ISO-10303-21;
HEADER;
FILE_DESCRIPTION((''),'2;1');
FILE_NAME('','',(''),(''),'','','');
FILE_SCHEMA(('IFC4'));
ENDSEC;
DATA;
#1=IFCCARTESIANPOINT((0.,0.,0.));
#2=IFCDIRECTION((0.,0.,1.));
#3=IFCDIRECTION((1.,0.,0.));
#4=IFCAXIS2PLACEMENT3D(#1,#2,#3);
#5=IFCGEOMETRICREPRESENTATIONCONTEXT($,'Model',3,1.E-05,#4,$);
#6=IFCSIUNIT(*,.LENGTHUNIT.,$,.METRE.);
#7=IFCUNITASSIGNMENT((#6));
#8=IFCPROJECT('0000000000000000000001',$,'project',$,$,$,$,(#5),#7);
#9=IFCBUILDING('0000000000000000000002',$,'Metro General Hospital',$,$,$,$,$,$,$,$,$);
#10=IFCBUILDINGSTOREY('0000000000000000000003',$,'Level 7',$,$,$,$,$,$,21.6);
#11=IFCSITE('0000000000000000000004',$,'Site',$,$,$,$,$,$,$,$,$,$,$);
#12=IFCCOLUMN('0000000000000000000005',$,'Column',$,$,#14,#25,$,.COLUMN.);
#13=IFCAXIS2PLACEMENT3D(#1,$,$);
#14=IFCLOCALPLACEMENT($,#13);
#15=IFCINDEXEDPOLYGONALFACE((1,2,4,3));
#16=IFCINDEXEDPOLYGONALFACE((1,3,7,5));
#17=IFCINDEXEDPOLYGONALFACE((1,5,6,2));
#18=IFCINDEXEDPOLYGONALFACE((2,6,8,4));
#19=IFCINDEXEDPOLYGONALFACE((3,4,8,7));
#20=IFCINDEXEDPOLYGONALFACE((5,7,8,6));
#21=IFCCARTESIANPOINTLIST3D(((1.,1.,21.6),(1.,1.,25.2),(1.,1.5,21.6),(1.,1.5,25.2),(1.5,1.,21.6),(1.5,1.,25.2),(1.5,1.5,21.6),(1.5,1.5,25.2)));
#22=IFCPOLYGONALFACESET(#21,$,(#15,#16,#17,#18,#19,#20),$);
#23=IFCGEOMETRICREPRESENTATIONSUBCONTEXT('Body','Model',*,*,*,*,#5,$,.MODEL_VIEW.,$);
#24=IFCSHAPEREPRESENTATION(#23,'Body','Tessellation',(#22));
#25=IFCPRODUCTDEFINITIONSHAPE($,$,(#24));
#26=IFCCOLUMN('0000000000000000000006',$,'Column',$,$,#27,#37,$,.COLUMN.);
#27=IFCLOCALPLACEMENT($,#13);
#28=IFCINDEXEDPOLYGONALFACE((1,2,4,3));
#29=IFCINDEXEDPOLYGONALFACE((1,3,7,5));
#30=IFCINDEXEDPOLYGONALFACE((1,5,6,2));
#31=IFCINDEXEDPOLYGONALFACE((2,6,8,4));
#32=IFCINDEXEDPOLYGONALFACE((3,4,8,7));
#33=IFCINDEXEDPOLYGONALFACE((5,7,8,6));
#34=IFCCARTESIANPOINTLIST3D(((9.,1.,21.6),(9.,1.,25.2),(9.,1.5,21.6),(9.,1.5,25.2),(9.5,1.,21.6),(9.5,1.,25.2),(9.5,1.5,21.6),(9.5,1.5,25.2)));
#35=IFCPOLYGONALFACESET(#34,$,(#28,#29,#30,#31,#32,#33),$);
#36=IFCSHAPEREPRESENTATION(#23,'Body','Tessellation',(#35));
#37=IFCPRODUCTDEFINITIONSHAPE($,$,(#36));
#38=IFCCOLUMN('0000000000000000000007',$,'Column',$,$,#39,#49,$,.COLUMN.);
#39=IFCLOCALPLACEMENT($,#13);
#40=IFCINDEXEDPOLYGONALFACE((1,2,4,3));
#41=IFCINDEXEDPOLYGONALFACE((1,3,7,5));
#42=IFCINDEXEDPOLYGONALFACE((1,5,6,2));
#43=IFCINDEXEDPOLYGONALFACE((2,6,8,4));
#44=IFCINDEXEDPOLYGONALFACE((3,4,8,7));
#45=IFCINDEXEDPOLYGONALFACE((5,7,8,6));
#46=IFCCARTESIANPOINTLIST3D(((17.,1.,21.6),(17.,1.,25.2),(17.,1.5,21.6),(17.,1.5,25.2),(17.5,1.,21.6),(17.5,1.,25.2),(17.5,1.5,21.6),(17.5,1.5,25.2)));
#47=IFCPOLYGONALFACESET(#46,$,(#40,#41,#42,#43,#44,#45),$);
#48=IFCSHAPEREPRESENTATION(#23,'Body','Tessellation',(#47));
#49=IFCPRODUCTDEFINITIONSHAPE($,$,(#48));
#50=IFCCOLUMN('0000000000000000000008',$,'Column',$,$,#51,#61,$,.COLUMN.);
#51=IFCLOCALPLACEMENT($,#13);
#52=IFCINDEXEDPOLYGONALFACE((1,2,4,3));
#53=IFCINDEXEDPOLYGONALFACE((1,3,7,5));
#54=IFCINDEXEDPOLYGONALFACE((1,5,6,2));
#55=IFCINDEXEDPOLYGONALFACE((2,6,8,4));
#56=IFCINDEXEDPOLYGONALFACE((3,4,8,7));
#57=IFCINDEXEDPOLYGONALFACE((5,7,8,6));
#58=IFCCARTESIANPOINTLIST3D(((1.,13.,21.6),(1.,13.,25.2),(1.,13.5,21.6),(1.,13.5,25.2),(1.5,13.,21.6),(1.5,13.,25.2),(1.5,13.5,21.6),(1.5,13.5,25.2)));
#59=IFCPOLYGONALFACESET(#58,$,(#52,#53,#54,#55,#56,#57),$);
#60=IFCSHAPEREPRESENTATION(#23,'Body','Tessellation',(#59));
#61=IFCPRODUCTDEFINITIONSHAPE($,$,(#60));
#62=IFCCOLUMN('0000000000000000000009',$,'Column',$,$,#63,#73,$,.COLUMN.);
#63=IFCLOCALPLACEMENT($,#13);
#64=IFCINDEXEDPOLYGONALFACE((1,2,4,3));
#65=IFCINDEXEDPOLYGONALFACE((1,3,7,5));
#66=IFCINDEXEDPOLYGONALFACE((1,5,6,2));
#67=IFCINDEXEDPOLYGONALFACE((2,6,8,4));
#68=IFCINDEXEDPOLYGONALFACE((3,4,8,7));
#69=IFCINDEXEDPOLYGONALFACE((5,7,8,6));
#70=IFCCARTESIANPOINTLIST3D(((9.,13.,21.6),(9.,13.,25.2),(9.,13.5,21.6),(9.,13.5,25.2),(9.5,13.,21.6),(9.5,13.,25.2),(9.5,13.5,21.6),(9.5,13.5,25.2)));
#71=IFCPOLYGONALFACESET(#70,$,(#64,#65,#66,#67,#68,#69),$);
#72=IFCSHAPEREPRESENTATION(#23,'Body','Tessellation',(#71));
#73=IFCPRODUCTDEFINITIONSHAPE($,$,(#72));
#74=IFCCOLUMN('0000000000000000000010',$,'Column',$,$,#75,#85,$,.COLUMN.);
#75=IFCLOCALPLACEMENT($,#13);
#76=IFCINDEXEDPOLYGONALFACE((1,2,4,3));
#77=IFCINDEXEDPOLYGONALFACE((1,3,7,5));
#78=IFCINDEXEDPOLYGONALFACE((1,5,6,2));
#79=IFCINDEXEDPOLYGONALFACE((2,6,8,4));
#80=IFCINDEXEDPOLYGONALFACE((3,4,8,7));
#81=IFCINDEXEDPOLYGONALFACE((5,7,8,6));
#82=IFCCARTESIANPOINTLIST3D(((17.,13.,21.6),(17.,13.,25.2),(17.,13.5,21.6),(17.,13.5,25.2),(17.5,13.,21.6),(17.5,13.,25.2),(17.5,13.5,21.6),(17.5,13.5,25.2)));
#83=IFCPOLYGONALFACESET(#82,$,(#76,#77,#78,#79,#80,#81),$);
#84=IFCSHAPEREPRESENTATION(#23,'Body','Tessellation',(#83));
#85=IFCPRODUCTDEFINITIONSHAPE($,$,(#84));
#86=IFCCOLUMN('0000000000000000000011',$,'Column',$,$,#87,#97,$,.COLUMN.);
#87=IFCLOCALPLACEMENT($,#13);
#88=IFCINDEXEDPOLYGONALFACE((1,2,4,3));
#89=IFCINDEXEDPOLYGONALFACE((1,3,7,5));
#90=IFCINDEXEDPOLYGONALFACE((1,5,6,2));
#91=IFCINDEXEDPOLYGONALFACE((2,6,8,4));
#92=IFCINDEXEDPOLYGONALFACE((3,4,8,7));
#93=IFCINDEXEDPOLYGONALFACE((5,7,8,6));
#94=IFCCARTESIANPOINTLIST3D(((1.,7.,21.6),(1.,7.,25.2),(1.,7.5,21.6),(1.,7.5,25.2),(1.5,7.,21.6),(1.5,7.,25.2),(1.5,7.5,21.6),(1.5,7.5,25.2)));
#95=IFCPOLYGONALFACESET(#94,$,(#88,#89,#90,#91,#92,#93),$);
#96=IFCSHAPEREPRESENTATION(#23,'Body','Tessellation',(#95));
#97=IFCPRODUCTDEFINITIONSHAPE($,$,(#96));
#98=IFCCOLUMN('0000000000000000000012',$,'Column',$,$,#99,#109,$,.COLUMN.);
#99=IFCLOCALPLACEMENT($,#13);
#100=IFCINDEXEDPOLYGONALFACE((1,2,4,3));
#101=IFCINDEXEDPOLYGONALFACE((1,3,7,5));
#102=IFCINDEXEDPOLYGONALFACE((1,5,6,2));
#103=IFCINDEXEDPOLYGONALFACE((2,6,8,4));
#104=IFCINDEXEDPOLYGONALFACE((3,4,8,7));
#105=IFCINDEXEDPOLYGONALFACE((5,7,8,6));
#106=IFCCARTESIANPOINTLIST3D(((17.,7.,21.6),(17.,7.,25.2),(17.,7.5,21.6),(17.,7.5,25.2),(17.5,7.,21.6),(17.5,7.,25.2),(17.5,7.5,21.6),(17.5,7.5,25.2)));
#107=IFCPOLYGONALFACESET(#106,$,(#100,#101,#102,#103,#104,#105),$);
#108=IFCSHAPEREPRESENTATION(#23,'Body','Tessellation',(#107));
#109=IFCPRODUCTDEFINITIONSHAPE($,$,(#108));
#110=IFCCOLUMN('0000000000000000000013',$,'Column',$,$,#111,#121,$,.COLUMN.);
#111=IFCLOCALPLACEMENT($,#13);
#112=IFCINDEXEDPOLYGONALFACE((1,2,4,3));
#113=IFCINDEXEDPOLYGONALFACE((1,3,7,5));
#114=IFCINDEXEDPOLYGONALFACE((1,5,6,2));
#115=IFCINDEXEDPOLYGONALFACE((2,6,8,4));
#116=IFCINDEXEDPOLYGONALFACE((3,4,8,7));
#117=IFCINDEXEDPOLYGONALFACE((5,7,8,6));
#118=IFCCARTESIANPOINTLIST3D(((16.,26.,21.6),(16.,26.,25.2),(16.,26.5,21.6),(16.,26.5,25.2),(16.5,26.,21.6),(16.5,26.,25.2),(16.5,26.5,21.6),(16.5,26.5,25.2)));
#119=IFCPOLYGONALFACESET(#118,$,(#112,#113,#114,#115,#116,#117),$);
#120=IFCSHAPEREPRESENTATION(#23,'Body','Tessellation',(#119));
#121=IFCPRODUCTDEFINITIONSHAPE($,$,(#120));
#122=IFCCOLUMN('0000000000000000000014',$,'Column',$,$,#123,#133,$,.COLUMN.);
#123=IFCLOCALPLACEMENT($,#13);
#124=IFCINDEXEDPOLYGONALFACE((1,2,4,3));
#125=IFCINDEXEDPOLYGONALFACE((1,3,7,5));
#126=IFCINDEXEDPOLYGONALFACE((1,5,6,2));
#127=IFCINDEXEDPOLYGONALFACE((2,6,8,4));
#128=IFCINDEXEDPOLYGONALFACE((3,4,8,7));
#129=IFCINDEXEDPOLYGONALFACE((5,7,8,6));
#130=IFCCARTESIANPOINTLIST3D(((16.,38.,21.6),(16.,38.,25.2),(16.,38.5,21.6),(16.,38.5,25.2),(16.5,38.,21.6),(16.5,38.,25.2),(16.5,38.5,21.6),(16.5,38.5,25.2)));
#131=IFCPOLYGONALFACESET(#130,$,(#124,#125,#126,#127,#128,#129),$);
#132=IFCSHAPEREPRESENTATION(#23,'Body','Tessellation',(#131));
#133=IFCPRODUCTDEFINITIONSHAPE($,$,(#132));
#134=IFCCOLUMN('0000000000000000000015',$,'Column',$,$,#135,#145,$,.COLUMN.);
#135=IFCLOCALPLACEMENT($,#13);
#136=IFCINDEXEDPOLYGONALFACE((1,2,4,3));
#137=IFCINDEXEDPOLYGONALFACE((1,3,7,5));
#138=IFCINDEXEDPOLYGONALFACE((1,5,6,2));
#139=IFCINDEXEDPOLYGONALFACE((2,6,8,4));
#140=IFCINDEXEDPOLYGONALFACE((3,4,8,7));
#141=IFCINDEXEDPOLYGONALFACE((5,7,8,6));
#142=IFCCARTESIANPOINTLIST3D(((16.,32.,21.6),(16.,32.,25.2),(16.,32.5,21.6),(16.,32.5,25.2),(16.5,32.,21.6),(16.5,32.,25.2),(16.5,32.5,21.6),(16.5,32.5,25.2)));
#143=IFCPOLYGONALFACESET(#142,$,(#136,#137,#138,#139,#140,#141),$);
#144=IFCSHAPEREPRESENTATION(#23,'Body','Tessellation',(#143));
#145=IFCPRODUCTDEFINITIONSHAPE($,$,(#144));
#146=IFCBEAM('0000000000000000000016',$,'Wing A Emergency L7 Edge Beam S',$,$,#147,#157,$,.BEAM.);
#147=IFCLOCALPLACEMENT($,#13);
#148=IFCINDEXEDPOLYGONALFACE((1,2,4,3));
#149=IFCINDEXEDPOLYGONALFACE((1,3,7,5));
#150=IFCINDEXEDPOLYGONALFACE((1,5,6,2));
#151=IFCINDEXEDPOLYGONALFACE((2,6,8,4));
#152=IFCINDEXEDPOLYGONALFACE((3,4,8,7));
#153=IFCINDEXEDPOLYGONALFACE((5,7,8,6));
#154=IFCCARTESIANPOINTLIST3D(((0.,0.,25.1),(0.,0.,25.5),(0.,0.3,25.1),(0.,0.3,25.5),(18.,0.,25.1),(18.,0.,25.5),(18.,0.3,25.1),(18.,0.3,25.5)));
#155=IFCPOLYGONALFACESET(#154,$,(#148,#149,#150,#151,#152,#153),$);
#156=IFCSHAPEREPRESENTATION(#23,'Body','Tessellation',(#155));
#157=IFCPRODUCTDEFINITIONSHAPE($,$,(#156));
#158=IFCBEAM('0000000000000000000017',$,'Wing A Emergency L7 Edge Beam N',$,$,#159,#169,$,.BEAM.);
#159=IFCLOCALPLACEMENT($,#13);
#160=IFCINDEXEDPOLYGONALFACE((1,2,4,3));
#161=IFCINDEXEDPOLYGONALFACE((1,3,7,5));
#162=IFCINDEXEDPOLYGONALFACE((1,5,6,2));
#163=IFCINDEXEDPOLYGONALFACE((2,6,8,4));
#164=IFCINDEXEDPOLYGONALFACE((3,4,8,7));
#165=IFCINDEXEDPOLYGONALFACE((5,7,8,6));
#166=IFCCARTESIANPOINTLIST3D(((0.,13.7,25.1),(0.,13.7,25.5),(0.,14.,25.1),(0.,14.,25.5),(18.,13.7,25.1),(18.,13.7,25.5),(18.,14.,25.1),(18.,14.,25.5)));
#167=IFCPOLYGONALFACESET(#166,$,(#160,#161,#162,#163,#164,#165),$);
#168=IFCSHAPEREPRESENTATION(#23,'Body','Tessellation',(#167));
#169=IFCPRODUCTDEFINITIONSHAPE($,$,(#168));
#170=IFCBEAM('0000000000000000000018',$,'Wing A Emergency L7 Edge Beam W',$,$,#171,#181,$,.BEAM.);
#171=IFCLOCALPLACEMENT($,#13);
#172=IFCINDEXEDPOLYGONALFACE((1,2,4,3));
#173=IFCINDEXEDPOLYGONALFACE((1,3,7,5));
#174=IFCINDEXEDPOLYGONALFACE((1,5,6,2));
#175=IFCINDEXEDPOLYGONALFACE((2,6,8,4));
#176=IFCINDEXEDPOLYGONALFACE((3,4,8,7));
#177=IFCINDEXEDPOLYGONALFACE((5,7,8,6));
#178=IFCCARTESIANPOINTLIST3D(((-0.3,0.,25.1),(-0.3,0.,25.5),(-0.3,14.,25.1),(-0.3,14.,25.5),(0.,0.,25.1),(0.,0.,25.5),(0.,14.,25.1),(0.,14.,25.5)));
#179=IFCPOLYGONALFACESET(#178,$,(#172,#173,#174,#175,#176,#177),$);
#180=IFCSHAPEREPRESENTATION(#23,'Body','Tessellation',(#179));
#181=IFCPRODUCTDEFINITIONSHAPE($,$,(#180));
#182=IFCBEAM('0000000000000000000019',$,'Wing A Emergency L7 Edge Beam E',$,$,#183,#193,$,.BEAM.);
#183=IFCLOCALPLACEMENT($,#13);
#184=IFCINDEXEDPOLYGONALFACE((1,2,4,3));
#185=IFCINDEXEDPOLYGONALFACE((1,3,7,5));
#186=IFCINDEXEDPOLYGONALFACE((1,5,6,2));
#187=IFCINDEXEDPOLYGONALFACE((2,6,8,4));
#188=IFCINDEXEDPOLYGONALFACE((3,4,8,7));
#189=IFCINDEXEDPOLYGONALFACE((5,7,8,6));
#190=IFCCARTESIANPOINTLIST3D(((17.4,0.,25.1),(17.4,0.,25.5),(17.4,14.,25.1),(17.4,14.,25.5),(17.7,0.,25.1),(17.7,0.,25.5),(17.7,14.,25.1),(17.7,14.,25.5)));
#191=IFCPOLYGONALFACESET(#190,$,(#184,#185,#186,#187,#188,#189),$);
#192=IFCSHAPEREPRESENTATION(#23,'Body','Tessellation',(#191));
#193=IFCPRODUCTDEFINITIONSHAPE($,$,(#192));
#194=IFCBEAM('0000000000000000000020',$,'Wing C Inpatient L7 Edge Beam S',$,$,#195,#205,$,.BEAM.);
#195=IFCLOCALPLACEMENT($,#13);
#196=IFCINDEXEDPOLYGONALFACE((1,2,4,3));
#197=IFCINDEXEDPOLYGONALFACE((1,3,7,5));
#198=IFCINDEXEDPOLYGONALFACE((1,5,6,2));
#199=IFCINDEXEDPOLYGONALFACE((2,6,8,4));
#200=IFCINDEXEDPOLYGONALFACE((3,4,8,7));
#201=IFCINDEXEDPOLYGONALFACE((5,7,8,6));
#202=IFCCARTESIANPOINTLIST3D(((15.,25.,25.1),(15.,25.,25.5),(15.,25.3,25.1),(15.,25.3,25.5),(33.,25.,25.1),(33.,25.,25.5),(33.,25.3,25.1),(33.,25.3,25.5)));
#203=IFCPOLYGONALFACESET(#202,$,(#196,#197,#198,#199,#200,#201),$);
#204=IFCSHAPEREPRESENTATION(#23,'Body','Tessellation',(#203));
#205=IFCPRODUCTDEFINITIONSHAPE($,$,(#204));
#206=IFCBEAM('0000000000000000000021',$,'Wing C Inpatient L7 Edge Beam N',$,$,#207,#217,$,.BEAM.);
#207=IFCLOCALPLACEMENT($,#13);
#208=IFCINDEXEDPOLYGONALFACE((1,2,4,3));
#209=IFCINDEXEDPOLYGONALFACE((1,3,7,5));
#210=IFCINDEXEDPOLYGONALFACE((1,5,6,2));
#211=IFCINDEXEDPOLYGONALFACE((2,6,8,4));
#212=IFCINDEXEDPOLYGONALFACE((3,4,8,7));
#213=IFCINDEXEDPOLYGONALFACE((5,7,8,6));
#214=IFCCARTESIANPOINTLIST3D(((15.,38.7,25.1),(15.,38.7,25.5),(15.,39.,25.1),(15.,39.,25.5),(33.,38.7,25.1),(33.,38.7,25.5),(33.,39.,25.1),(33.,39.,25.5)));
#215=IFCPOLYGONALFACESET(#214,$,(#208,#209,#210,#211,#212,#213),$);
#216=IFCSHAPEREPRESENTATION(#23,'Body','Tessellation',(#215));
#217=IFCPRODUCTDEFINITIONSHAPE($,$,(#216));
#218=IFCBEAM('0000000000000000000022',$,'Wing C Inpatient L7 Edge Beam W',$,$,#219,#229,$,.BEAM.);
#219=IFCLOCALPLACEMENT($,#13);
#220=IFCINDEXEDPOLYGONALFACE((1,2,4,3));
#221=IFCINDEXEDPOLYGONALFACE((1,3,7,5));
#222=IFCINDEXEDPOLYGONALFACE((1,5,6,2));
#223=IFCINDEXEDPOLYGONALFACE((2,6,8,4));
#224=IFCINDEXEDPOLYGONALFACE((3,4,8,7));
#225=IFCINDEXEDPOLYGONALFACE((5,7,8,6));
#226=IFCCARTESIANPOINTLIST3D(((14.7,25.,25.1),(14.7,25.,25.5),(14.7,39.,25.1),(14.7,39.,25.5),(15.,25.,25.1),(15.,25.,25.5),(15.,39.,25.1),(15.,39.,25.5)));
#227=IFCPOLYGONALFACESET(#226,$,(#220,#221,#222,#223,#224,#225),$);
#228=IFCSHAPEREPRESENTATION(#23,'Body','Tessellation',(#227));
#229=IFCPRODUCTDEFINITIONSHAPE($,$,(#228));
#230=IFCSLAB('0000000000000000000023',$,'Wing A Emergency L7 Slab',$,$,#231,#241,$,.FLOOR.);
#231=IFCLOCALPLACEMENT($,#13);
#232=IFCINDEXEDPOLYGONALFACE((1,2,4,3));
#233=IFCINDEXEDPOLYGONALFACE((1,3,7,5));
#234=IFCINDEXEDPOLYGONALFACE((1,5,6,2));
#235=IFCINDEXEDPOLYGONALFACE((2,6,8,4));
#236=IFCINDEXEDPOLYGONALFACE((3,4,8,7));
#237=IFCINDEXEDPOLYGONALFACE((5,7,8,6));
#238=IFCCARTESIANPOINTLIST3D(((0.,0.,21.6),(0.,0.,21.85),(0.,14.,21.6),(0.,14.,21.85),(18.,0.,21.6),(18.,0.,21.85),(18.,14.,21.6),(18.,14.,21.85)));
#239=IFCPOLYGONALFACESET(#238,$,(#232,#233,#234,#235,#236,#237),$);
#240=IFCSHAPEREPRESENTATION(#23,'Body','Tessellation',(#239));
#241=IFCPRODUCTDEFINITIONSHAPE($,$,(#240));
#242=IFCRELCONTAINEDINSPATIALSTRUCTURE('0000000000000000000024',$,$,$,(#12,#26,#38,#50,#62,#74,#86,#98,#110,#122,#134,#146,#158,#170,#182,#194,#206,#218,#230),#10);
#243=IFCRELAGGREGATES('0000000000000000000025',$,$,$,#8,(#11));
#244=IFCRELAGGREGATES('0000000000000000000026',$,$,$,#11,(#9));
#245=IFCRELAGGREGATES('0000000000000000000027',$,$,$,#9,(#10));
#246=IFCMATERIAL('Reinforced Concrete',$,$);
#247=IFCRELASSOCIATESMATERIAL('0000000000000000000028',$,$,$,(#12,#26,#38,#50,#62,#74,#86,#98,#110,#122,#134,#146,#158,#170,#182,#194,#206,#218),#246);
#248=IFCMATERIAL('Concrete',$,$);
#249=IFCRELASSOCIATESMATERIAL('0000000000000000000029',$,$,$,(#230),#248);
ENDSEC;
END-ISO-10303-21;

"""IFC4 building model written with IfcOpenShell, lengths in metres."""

from ifc_helpers import new_model, si_unit, frame, origin_with_axes, place, context, subcontext, project, spatial, line, indexed_curve, outline, extrude, material, element, save


model = new_model("IFC4")

# Units and contexts
model_context = context("Model", 3, precision=1e-05, world=origin_with_axes())
body_context = subcontext(model_context, "Body", "Model", "MODEL_VIEW")
ifc_project = project(units=[si_unit("LENGTHUNIT", "METRE")], contexts=[model_context])

# Site, building, storey
site = spatial("IfcSite", under=ifc_project, Name="Site")
building = spatial("IfcBuilding", under=site, Name="Metro General Hospital")
storey = spatial("IfcBuildingStorey", under=building, Name="Level 7", Elevation=21.6)

# Columns
ifc_material_1 = material(Name="Reinforced Concrete")
for number, where, z_axis, x_axis, name in (
    (1, (1.0, 1.0, 21.6), (0.0, 0.0, 1.0), (1.0, 0.0, 0.0), "Column"),
    (2, (9.0, 1.0, 21.6), (0.0, 0.0, 1.0), (1.0, 0.0, 0.0), "Column"),
    (3, (17.0, 1.0, 21.6), (0.0, 0.0, 1.0), (1.0, 0.0, 0.0), "Column"),
    (4, (1.0, 13.0, 21.6), (0.0, 0.0, 1.0), (1.0, 0.0, 0.0), "Column"),
    (5, (9.0, 13.0, 21.6), (0.0, 0.0, 1.0), (1.0, 0.0, 0.0), "Column"),
    (6, (17.0, 13.0, 21.6), (0.0, 0.0, 1.0), (1.0, 0.0, 0.0), "Column"),
    (7, (1.0, 7.0, 21.6), (0.0, 0.0, 1.0), (1.0, 0.0, 0.0), "Column"),
    (8, (17.0, 7.0, 21.6), (0.0, 0.0, 1.0), (1.0, 0.0, 0.0), "Column"),
    (9, (16.0, 26.0, 21.6), (0.0, 0.0, 1.0), (1.0, 0.0, 0.0), "Column"),
    (10, (16.0, 38.0, 21.6), (0.0, 0.0, 1.0), (1.0, 0.0, 0.0), "Column"),
    (11, (16.0, 32.0, 21.6), (0.0, 0.0, 1.0), (1.0, 0.0, 0.0), "Column"),
):
    element("IfcColumn", number, at=place(None, frame(where, z_axis=z_axis, x_axis=x_axis)), inside=storey, material=ifc_material_1, Name=name, PredefinedType="COLUMN", context=body_context, shape_type="SweptSolid", body=[
        extrude(outline(indexed_curve([(0.0, 0.0), (0.5, 0.0), (0.5, 0.5), (0.0, 0.5)], segments=[line(1, 2, 3, 4, 1)])), origin_with_axes(), (0.0, 0.0, 1.0), 3.6),
    ])

# Beams
for number, where, z_axis, x_axis, name in (
    (12, (0.0, 0.0, 25.1), (0.0, 0.0, 1.0), (1.0, 0.0, 0.0), "Wing A Emergency L7 Edge Beam S"),
    (13, (0.0, 13.7, 25.1), (0.0, 0.0, 1.0), (1.0, 0.0, 0.0), "Wing A Emergency L7 Edge Beam N"),
):
    element("IfcBeam", number, at=place(None, frame(where, z_axis=z_axis, x_axis=x_axis)), inside=storey, material=ifc_material_1, Name=name, PredefinedType="BEAM", context=body_context, shape_type="SweptSolid", body=[
        extrude(outline(indexed_curve([(0.0, 0.0), (18.0, 0.0), (18.0, 0.3), (0.0, 0.3)], segments=[line(1, 2, 3, 4, 1)])), origin_with_axes(), (0.0, 0.0, 1.0), 0.4),
    ])
for number, where, z_axis, x_axis, name in (
    (14, (0.0, 0.0, 25.1), (0.0, 0.0, 1.0), (0.0, 1.0, 0.0), "Wing A Emergency L7 Edge Beam W"),
    (15, (17.7, 0.0, 25.1), (0.0, 0.0, 1.0), (0.0, 1.0, 0.0), "Wing A Emergency L7 Edge Beam E"),
):
    element("IfcBeam", number, at=place(None, frame(where, z_axis=z_axis, x_axis=x_axis)), inside=storey, material=ifc_material_1, Name=name, PredefinedType="BEAM", context=body_context, shape_type="SweptSolid", body=[
        extrude(outline(indexed_curve([(0.0, 0.0), (14.0, 0.0), (14.0, 0.3), (0.0, 0.3)], segments=[line(1, 2, 3, 4, 1)])), origin_with_axes(), (0.0, 0.0, 1.0), 0.4),
    ])
for number, where, z_axis, x_axis, name in (
    (16, (15.0, 25.0, 25.1), (0.0, 0.0, 1.0), (1.0, 0.0, 0.0), "Wing C Inpatient L7 Edge Beam S"),
    (17, (15.0, 38.7, 25.1), (0.0, 0.0, 1.0), (1.0, 0.0, 0.0), "Wing C Inpatient L7 Edge Beam N"),
):
    element("IfcBeam", number, at=place(None, frame(where, z_axis=z_axis, x_axis=x_axis)), inside=storey, material=ifc_material_1, Name=name, PredefinedType="BEAM", context=body_context, shape_type="SweptSolid", body=[
        extrude(outline(indexed_curve([(0.0, 0.0), (18.0, 0.0), (18.0, 0.3), (0.0, 0.3)], segments=[line(1, 2, 3, 4, 1)])), origin_with_axes(), (0.0, 0.0, 1.0), 0.4),
    ])
beam_placement = place(None, frame((15.0, 25.0, 25.1), z_axis=(0.0, 0.0, 1.0), x_axis=(0.0, 1.0, 0.0)))
element("IfcBeam", 18, at=beam_placement, inside=storey, material=ifc_material_1, Name="Wing C Inpatient L7 Edge Beam W", PredefinedType="BEAM", context=body_context, shape_type="SweptSolid", body=[
    extrude(outline(indexed_curve([(0.0, 0.0), (14.0, 0.0), (14.0, 0.3), (0.0, 0.3)], segments=[line(1, 2, 3, 4, 1)])), origin_with_axes(), (0.0, 0.0, 1.0), 0.4),
])

# Slab
ifc_material_2 = material(Name="Concrete")
for number, where, z_axis, x_axis, name in (
    (19, (0.0, 0.0, 21.6), (0.0, 0.0, 1.0), (1.0, 0.0, 0.0), "Wing A Emergency L7 Slab"),
):
    element("IfcSlab", number, at=place(None, frame(where, z_axis=z_axis, x_axis=x_axis)), inside=storey, material=ifc_material_2, Name=name, PredefinedType="FLOOR", context=body_context, shape_type="SweptSolid", body=[
        extrude(outline(indexed_curve([(0.0, 0.0), (18.0, 0.0), (18.0, 14.0), (0.0, 14.0)], segments=[line(1, 2, 3, 4, 1)])), origin_with_axes(), (0.0, 0.0, 1.0), 0.25),
    ])

save(model, "model.ifc")
